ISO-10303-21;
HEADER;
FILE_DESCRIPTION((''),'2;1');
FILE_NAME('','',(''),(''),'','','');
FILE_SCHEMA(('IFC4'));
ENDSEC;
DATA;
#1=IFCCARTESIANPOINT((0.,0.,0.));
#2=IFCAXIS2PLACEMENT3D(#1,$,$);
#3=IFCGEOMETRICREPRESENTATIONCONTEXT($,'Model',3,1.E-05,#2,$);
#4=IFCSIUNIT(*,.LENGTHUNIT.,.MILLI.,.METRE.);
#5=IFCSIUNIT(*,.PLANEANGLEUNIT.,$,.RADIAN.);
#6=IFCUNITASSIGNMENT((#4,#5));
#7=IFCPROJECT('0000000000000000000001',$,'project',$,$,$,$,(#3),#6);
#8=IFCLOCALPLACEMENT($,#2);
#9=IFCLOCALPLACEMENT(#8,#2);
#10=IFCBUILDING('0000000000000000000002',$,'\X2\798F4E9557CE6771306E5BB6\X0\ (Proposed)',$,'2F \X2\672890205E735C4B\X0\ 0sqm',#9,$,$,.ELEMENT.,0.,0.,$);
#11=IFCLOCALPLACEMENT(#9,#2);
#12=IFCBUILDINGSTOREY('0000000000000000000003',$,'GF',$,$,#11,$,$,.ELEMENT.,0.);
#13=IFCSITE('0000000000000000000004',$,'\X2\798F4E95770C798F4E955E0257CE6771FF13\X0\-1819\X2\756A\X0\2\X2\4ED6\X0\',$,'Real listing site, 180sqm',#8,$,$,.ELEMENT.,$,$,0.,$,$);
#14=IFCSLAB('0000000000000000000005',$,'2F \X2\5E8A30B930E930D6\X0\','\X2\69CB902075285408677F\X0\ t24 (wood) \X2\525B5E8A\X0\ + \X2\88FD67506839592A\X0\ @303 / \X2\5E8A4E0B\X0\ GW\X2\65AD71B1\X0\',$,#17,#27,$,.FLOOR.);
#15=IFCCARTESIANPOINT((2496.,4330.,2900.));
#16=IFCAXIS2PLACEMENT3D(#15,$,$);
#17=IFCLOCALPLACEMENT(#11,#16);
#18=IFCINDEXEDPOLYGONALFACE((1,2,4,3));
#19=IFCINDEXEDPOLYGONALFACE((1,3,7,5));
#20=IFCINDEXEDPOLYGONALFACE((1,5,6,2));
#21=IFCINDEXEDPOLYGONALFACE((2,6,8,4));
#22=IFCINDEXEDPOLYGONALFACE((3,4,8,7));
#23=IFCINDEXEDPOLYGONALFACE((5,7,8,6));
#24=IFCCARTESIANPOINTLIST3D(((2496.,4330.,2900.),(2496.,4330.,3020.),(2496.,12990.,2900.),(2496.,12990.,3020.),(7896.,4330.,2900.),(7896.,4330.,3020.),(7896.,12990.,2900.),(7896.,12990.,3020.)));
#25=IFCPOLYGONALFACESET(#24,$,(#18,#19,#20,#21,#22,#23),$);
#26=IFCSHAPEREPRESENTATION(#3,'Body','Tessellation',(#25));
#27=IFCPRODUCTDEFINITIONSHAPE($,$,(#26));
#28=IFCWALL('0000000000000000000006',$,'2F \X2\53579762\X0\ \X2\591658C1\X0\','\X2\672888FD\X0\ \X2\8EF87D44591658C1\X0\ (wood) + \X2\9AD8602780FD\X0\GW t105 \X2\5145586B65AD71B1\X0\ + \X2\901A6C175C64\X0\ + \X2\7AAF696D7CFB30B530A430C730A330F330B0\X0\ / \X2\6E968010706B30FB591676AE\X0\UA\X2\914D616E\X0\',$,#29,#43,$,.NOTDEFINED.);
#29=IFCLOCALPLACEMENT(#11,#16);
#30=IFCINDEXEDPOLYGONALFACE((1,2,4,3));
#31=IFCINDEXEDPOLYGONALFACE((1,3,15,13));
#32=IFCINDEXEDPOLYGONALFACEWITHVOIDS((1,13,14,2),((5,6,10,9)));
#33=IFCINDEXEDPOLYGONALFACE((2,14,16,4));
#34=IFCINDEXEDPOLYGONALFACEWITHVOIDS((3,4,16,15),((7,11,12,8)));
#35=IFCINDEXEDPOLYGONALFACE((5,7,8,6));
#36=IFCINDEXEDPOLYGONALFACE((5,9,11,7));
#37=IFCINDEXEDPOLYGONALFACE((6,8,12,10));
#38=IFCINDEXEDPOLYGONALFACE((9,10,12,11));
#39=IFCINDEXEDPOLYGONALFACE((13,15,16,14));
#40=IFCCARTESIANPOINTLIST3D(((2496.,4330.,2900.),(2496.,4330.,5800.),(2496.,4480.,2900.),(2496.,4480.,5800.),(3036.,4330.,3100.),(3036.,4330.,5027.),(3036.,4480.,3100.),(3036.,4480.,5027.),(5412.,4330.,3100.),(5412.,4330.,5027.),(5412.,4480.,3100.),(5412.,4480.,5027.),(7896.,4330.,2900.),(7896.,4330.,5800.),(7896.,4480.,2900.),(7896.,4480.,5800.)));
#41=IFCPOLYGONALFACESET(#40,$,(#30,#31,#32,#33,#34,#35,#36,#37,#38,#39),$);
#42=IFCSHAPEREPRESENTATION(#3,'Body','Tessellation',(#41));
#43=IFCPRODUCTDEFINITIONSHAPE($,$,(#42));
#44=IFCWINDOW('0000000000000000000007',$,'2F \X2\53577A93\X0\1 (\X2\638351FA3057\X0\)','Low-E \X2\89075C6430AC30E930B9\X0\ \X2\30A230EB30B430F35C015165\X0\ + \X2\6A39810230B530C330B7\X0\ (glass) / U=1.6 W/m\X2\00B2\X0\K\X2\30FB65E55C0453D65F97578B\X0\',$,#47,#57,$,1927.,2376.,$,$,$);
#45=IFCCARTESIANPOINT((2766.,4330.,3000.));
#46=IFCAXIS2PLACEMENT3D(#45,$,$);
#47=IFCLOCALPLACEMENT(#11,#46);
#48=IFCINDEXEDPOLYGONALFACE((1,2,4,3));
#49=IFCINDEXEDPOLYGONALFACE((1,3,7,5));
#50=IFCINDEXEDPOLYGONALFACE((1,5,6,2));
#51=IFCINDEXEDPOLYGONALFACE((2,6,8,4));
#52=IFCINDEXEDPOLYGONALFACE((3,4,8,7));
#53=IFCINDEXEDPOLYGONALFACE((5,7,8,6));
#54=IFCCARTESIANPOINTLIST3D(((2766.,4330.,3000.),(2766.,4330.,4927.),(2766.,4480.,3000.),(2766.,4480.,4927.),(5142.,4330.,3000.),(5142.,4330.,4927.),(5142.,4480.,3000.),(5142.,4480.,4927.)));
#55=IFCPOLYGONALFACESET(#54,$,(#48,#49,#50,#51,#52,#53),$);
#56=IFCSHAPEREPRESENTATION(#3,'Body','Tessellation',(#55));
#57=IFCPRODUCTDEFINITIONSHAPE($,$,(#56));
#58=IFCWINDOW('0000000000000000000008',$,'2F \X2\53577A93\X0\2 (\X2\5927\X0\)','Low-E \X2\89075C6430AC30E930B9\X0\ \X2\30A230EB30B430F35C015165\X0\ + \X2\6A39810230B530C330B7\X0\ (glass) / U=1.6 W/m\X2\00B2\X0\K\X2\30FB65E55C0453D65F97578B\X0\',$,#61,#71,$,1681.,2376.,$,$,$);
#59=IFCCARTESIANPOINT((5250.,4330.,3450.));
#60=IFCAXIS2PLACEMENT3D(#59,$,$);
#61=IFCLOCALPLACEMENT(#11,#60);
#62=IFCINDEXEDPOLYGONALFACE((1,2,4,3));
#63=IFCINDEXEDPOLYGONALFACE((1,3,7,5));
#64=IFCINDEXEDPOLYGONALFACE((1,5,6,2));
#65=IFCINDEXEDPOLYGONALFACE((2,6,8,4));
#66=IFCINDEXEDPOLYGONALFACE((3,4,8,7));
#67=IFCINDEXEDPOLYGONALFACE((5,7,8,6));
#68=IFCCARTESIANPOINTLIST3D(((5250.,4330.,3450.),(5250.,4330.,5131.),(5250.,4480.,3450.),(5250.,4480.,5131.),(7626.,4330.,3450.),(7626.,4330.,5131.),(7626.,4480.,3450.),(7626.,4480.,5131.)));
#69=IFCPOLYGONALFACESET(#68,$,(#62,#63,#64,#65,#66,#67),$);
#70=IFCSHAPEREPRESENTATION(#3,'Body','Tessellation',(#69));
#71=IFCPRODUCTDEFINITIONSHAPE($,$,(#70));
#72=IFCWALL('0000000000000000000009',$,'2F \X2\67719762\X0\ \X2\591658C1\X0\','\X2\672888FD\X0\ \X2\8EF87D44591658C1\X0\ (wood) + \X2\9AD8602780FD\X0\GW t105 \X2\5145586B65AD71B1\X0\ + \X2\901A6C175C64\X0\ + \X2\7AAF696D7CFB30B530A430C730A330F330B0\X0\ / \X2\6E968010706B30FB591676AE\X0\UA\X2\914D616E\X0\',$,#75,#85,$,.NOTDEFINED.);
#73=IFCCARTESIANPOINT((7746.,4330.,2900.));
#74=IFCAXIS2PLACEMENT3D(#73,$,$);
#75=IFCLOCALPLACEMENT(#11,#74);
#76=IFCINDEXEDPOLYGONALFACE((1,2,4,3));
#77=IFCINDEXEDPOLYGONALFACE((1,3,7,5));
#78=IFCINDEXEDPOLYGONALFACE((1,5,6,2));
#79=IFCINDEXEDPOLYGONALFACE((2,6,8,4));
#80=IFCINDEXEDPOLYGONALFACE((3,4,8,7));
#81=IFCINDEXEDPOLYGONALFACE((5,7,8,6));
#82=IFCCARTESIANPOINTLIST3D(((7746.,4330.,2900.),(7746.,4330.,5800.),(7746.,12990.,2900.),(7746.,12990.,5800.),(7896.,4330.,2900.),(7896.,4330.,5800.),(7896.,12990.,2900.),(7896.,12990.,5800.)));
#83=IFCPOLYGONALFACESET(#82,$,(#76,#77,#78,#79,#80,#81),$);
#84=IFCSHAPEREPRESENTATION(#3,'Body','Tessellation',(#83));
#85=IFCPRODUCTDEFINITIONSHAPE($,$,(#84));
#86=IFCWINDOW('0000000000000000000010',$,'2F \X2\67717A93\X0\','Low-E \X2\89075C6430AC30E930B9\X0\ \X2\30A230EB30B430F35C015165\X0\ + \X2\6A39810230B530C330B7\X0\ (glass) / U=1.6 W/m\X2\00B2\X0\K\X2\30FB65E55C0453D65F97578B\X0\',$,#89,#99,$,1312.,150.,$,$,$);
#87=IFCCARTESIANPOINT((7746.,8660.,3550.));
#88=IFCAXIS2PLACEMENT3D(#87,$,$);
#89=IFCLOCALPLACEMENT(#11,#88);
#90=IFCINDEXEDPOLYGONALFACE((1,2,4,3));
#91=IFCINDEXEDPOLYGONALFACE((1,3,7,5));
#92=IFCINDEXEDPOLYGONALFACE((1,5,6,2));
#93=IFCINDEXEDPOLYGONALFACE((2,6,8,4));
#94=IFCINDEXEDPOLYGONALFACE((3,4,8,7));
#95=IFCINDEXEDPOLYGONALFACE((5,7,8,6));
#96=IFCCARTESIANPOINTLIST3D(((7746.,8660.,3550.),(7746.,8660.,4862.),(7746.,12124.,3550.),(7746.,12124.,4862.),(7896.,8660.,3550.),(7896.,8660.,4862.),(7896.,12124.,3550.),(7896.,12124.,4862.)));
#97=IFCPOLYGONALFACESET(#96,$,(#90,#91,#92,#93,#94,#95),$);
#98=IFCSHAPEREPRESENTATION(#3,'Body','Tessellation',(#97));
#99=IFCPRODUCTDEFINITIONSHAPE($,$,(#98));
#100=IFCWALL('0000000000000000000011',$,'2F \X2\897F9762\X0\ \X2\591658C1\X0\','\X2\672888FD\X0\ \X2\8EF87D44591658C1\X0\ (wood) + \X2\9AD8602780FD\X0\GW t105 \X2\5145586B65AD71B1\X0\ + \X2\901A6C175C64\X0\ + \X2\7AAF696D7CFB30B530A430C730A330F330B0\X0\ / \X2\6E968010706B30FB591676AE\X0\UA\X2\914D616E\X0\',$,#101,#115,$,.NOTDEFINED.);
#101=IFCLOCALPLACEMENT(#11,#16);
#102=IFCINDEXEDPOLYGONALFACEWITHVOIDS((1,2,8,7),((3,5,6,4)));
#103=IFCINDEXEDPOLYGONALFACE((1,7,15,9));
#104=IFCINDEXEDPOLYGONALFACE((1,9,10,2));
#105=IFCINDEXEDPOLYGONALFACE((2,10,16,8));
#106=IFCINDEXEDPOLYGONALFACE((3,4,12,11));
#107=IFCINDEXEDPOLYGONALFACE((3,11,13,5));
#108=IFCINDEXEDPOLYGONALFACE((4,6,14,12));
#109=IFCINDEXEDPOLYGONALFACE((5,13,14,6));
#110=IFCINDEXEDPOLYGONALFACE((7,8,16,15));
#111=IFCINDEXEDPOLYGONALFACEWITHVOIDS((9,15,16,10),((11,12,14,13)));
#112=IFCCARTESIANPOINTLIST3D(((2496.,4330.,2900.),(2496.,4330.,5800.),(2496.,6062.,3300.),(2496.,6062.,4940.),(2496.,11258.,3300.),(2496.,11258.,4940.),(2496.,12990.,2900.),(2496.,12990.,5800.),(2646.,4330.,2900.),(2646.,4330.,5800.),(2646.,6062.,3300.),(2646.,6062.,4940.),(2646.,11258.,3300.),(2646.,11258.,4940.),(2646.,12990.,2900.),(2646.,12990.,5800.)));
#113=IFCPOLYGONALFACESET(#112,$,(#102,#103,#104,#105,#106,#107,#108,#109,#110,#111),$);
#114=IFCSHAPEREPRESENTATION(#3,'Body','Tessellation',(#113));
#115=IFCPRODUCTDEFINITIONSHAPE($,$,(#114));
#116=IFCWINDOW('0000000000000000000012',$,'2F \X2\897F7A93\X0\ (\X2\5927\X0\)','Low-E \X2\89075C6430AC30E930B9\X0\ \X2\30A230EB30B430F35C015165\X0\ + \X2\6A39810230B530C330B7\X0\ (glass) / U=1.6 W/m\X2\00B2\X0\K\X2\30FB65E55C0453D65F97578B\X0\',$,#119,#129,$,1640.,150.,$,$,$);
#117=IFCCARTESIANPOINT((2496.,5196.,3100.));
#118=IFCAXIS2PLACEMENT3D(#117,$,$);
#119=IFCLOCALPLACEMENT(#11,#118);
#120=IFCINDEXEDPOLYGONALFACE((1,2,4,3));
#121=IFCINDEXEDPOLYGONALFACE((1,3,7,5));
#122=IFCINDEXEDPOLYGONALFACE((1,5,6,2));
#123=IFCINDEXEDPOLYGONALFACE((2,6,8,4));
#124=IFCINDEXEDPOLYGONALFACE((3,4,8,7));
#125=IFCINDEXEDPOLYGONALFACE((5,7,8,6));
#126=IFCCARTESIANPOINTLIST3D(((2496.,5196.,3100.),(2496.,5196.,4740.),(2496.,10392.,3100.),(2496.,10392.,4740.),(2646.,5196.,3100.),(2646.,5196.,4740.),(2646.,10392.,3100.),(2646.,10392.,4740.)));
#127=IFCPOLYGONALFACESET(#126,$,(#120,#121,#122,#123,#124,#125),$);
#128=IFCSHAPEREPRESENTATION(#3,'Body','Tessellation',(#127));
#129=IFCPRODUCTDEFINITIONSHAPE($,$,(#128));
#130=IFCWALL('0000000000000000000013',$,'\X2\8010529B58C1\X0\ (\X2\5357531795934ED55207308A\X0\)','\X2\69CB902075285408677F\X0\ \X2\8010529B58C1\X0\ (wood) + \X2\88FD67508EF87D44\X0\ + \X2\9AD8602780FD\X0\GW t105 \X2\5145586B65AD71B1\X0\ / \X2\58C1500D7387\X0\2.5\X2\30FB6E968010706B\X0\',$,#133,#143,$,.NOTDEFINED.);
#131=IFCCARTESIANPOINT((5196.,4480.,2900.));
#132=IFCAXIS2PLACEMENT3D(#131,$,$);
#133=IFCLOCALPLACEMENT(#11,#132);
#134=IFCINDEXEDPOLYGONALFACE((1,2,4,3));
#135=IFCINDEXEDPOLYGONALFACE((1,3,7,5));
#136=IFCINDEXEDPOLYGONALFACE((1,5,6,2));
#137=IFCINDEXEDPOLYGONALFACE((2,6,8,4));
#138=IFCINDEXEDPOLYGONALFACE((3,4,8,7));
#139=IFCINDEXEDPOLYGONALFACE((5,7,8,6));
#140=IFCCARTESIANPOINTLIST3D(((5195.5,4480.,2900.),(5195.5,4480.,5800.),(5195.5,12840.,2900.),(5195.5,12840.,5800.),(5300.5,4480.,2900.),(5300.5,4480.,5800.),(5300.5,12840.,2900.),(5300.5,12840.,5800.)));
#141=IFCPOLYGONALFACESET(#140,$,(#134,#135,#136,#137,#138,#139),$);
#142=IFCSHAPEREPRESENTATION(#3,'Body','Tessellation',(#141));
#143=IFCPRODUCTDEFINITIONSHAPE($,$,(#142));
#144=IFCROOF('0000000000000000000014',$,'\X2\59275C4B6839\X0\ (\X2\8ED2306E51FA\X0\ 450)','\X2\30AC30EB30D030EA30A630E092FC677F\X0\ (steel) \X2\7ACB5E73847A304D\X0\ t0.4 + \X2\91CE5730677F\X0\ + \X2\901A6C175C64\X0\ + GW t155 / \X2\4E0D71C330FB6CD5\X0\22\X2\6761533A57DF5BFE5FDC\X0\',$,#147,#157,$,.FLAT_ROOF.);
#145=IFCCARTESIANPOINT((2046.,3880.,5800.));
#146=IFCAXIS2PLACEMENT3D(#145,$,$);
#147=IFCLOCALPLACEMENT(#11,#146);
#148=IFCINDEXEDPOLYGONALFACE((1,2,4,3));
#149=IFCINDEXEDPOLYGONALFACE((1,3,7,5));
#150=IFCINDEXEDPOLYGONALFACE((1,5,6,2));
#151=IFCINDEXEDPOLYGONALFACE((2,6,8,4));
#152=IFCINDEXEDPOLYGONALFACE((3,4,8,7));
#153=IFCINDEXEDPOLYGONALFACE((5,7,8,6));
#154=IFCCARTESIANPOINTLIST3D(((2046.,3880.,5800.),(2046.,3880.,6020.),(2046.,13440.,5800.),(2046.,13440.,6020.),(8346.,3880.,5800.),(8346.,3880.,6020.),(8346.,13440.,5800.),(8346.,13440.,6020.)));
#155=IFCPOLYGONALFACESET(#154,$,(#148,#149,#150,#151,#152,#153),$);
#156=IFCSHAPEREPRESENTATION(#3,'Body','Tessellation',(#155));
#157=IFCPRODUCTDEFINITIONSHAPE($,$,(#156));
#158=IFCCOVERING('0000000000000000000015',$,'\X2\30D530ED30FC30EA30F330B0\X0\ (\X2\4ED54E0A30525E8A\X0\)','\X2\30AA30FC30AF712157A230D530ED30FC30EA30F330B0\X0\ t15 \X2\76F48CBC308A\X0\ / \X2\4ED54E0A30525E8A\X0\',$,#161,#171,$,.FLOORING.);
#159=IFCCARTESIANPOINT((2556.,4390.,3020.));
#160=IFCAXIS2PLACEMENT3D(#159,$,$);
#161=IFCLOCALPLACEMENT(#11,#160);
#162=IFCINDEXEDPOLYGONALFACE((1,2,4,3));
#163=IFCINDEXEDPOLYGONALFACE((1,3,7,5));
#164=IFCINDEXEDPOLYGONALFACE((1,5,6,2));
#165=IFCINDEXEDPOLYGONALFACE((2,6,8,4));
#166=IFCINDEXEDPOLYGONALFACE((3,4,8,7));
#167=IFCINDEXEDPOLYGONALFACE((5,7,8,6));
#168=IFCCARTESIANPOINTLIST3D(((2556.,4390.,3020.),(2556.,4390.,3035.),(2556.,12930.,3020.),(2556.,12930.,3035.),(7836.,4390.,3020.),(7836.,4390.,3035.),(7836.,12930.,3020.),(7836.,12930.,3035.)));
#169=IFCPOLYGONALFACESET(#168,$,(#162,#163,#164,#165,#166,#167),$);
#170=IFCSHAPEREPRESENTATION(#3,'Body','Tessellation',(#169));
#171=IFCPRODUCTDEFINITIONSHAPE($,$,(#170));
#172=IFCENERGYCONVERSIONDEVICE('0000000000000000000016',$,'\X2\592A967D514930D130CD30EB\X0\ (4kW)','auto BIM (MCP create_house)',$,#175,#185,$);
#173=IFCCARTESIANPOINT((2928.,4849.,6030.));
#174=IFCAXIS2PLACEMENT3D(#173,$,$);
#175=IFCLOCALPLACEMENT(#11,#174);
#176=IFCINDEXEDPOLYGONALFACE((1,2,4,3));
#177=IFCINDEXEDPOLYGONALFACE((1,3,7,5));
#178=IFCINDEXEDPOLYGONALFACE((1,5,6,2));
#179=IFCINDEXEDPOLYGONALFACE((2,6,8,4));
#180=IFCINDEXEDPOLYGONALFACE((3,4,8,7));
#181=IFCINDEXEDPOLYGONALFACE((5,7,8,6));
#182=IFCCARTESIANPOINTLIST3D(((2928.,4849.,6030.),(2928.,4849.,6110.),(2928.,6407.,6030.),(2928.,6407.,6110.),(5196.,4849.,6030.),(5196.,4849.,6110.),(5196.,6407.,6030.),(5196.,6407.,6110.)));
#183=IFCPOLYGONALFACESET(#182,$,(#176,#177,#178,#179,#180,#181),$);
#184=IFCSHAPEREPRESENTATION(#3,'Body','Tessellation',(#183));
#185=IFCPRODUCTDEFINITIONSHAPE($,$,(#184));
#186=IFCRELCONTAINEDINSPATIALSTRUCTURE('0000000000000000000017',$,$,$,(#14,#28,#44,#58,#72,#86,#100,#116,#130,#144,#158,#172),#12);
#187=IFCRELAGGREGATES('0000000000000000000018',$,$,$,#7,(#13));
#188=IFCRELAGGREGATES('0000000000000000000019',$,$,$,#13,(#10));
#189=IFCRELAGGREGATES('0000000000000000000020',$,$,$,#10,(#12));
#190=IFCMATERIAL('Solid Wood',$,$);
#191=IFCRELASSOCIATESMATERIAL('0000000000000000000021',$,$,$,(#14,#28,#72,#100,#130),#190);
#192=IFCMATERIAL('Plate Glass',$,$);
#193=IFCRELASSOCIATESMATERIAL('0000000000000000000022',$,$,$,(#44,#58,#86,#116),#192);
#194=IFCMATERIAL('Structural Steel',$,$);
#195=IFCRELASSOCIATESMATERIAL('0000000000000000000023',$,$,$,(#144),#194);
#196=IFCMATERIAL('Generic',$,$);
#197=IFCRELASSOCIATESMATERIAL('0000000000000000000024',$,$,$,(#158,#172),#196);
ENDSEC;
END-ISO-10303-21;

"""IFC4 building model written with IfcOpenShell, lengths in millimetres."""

from ifc_helpers import new_model, si_unit, frame, frame_2d, origin, place, context, project, spatial, rectangle, extrude, material, element, fill, save


model = new_model("IFC4")

# Units and contexts
model_context = context("Model", 3, precision=1e-05, world=origin())
ifc_project = project(units=[si_unit("LENGTHUNIT", "METRE", prefix="MILLI"), si_unit("PLANEANGLEUNIT", "RADIAN")], contexts=[model_context])

# Site, building, storey
site_placement = place(None, origin())
site = spatial("IfcSite", under=ifc_project, at=site_placement, Name="福井県福井市城東３-1819番2他", ObjectType="Real listing site, 180sqm", CompositionType="ELEMENT", RefElevation=0.0)
building_placement = place(site_placement, origin())
building = spatial("IfcBuilding", under=site, at=building_placement, Name="福井城東の家 (Proposed)", ObjectType="2F 木造平屋 0sqm", CompositionType="ELEMENT", ElevationOfRefHeight=0.0, ElevationOfTerrain=0.0)
storey_placement = place(building_placement, origin())
storey = spatial("IfcBuildingStorey", under=building, at=storey_placement, Name="GF", CompositionType="ELEMENT", Elevation=0.0)

# Slab
ifc_material_1 = material(Name="Solid Wood")
slab_placement = place(storey_placement, frame((2496.0, 4330.0, 2900.0)))
element("IfcSlab", 1, at=slab_placement, inside=storey, material=ifc_material_1, Name="2F 床スラブ", Description="構造用合板 t24 (wood) 剛床 + 製材根太 @303 / 床下 GW断熱", PredefinedType="FLOOR", context=model_context, shape_type="SweptSolid", body=[
    extrude(rectangle(XDim=5400.0, YDim=8660.0, at=frame_2d((2700.0, 4330.0))), frame((2496.0, 4330.0, 2900.0)), (0.0, 0.0, 1.0), 120.0),
])

# Wall, openings, windows
wall_1_placement = place(storey_placement, frame((2496.0, 4330.0, 2900.0)))
wall_1 = element("IfcWall", 2, at=wall_1_placement, inside=storey, material=ifc_material_1, Name="2F 南面 外壁", Description="木製 軸組外壁 (wood) + 高性能GW t105 充填断熱 + 通気層 + 窯業系サイディング / 準耐火・外皮UA配慮", PredefinedType="NOTDEFINED", context=model_context, shape_type="SweptSolid", body=[
    extrude(rectangle(XDim=5400.0, YDim=150.0, at=frame_2d((2700.0, 75.0))), frame((2496.0, 4330.0, 2900.0)), (0.0, 0.0, 1.0), 2900.0),
])
opening_1_placement = place(storey_placement, frame((2766.0, 4330.0, 3000.0)))
opening_1 = element("IfcOpeningElement", 3, at=opening_1_placement, cuts=wall_1, PredefinedType="NOTDEFINED", context=model_context, shape_type="SweptSolid", body=[
    extrude(rectangle(XDim=2376.0, YDim=150.0, at=frame_2d((1188.0, 75.0))), frame((2766.0, 4330.0, 3000.0)), (0.0, 0.0, 1.0), 1927.0),
])
opening_2_placement = place(storey_placement, frame((5250.0, 4330.0, 3450.0)))
opening_2 = element("IfcOpeningElement", 4, at=opening_2_placement, cuts=wall_1, PredefinedType="NOTDEFINED", context=model_context, shape_type="SweptSolid", body=[
    extrude(rectangle(XDim=2376.0, YDim=150.0, at=frame_2d((1188.0, 75.0))), frame((5250.0, 4330.0, 3450.0)), (0.0, 0.0, 1.0), 1681.0),
])
ifc_material_2 = material(Name="Plate Glass")
window_1_placement = place(storey_placement, frame((2766.0, 4330.0, 3000.0)))
window_1 = element("IfcWindow", 5, at=window_1_placement, inside=storey, material=ifc_material_2, Name="2F 南窓1 (掃出し)", Description="Low-E 複層ガラス アルゴン封入 + 樹脂サッシ (glass) / U=1.6 W/m²K・日射取得型", OverallHeight=1927.0, OverallWidth=2376.0, context=model_context, shape_type="SweptSolid", body=[
    extrude(rectangle(XDim=2376.0, YDim=150.0, at=frame_2d((1188.0, 75.0))), frame((2766.0, 4330.0, 3000.0)), (0.0, 0.0, 1.0), 1927.0),
])
fill(opening_1, window_1)
window_2_placement = place(storey_placement, frame((5250.0, 4330.0, 3450.0)))
window_2 = element("IfcWindow", 6, at=window_2_placement, inside=storey, material=ifc_material_2, Name="2F 南窓2 (大)", Description="Low-E 複層ガラス アルゴン封入 + 樹脂サッシ (glass) / U=1.6 W/m²K・日射取得型", OverallHeight=1681.0, OverallWidth=2376.0, context=model_context, shape_type="SweptSolid", body=[
    extrude(rectangle(XDim=2376.0, YDim=150.0, at=frame_2d((1188.0, 75.0))), frame((5250.0, 4330.0, 3450.0)), (0.0, 0.0, 1.0), 1681.0),
])
fill(opening_2, window_2)

# Walls, openings, windows
wall_2_placement = place(storey_placement, frame((7746.0, 4330.0, 2900.0)))
wall_2 = element("IfcWall", 7, at=wall_2_placement, inside=storey, material=ifc_material_1, Name="2F 東面 外壁", Description="木製 軸組外壁 (wood) + 高性能GW t105 充填断熱 + 通気層 + 窯業系サイディング / 準耐火・外皮UA配慮", PredefinedType="NOTDEFINED", context=model_context, shape_type="SweptSolid", body=[
    extrude(rectangle(XDim=150.0, YDim=8660.0, at=frame_2d((75.0, 4330.0))), frame((7746.0, 4330.0, 2900.0)), (0.0, 0.0, 1.0), 2900.0),
])
opening_3_placement = place(storey_placement, frame((7746.0, 8660.0, 3550.0)))
opening_3 = element("IfcOpeningElement", 8, at=opening_3_placement, cuts=wall_2, PredefinedType="NOTDEFINED", context=model_context, shape_type="SweptSolid", body=[
    extrude(rectangle(XDim=150.0, YDim=3464.0, at=frame_2d((75.0, 1732.0))), frame((7746.0, 8660.0, 3550.0)), (0.0, 0.0, 1.0), 1312.0),
])
window_3_placement = place(storey_placement, frame((7746.0, 8660.0, 3550.0)))
window_3 = element("IfcWindow", 9, at=window_3_placement, inside=storey, material=ifc_material_2, Name="2F 東窓", Description="Low-E 複層ガラス アルゴン封入 + 樹脂サッシ (glass) / U=1.6 W/m²K・日射取得型", OverallHeight=1312.0, OverallWidth=150.0, context=model_context, shape_type="SweptSolid", body=[
    extrude(rectangle(XDim=150.0, YDim=3464.0, at=frame_2d((75.0, 1732.0))), frame((7746.0, 8660.0, 3550.0)), (0.0, 0.0, 1.0), 1312.0),
])
fill(opening_3, window_3)
wall_3_placement = place(storey_placement, frame((2496.0, 4330.0, 2900.0)))
wall_3 = element("IfcWall", 10, at=wall_3_placement, inside=storey, material=ifc_material_1, Name="2F 西面 外壁", Description="木製 軸組外壁 (wood) + 高性能GW t105 充填断熱 + 通気層 + 窯業系サイディング / 準耐火・外皮UA配慮", PredefinedType="NOTDEFINED", context=model_context, shape_type="SweptSolid", body=[
    extrude(rectangle(XDim=150.0, YDim=8660.0, at=frame_2d((75.0, 4330.0))), frame((2496.0, 4330.0, 2900.0)), (0.0, 0.0, 1.0), 2900.0),
])
opening_4_placement = place(storey_placement, frame((2496.0, 5196.0, 3100.0)))
opening_4 = element("IfcOpeningElement", 11, at=opening_4_placement, cuts=wall_3, PredefinedType="NOTDEFINED", context=model_context, shape_type="SweptSolid", body=[
    extrude(rectangle(XDim=150.0, YDim=5196.0, at=frame_2d((75.0, 2598.0))), frame((2496.0, 5196.0, 3100.0)), (0.0, 0.0, 1.0), 1640.0),
])
window_4_placement = place(storey_placement, frame((2496.0, 5196.0, 3100.0)))
window_4 = element("IfcWindow", 12, at=window_4_placement, inside=storey, material=ifc_material_2, Name="2F 西窓 (大)", Description="Low-E 複層ガラス アルゴン封入 + 樹脂サッシ (glass) / U=1.6 W/m²K・日射取得型", OverallHeight=1640.0, OverallWidth=150.0, context=model_context, shape_type="SweptSolid", body=[
    extrude(rectangle(XDim=150.0, YDim=5196.0, at=frame_2d((75.0, 2598.0))), frame((2496.0, 5196.0, 3100.0)), (0.0, 0.0, 1.0), 1640.0),
])
fill(opening_4, window_4)

# Wall
wall_4_placement = place(storey_placement, frame((5196.0, 4480.0, 2900.0)))
element("IfcWall", 13, at=wall_4_placement, inside=storey, material=ifc_material_1, Name="耐力壁 (南北間仕切り)", Description="構造用合板 耐力壁 (wood) + 製材軸組 + 高性能GW t105 充填断熱 / 壁倍率2.5・準耐火", PredefinedType="NOTDEFINED", context=model_context, shape_type="SweptSolid", body=[
    extrude(rectangle(XDim=105.0, YDim=8360.0, at=frame_2d((52.0, 4180.0))), frame((5196.0, 4480.0, 2900.0)), (0.0, 0.0, 1.0), 2900.0),
])

# Roof
ifc_material_3 = material(Name="Structural Steel")
roof_placement = place(storey_placement, frame((2046.0, 3880.0, 5800.0)))
element("IfcRoof", 14, at=roof_placement, inside=storey, material=ifc_material_3, Name="大屋根 (軒の出 450)", Description="ガルバリウム鋼板 (steel) 立平葺き t0.4 + 野地板 + 通気層 + GW t155 / 不燃・法22条区域対応", PredefinedType="FLAT_ROOF", context=model_context, shape_type="SweptSolid", body=[
    extrude(rectangle(XDim=6300.0, YDim=9560.0, at=frame_2d((3150.0, 4780.0))), frame((2046.0, 3880.0, 5800.0)), (0.0, 0.0, 1.0), 220.0),
])

# Covering
ifc_material_4 = material(Name="Generic")
covering_placement = place(storey_placement, frame((2556.0, 4390.0, 3020.0)))
element("IfcCovering", 15, at=covering_placement, inside=storey, material=ifc_material_4, Name="フローリング (仕上げ床)", Description="オーク無垢フローリング t15 直貼り / 仕上げ床", PredefinedType="FLOORING", context=model_context, shape_type="SweptSolid", body=[
    extrude(rectangle(XDim=5280.0, YDim=8540.0, at=frame_2d((2640.0, 4270.0))), frame((2556.0, 4390.0, 3020.0)), (0.0, 0.0, 1.0), 15.0),
])

# Energy conversion device
energy_conversion_device_placement = place(storey_placement, frame((2928.0, 4849.0, 6030.0)))
element("IfcEnergyConversionDevice", 16, at=energy_conversion_device_placement, inside=storey, material=ifc_material_4, Name="太陽光パネル (4kW)", Description="auto BIM (MCP create_house)", context=model_context, shape_type="SweptSolid", body=[
    extrude(rectangle(XDim=2268.0, YDim=1558.0, at=frame_2d((1134.0, 779.0))), frame((2928.0, 4849.0, 6030.0)), (0.0, 0.0, 1.0), 80.0),
])

save(model, "model.ifc")
